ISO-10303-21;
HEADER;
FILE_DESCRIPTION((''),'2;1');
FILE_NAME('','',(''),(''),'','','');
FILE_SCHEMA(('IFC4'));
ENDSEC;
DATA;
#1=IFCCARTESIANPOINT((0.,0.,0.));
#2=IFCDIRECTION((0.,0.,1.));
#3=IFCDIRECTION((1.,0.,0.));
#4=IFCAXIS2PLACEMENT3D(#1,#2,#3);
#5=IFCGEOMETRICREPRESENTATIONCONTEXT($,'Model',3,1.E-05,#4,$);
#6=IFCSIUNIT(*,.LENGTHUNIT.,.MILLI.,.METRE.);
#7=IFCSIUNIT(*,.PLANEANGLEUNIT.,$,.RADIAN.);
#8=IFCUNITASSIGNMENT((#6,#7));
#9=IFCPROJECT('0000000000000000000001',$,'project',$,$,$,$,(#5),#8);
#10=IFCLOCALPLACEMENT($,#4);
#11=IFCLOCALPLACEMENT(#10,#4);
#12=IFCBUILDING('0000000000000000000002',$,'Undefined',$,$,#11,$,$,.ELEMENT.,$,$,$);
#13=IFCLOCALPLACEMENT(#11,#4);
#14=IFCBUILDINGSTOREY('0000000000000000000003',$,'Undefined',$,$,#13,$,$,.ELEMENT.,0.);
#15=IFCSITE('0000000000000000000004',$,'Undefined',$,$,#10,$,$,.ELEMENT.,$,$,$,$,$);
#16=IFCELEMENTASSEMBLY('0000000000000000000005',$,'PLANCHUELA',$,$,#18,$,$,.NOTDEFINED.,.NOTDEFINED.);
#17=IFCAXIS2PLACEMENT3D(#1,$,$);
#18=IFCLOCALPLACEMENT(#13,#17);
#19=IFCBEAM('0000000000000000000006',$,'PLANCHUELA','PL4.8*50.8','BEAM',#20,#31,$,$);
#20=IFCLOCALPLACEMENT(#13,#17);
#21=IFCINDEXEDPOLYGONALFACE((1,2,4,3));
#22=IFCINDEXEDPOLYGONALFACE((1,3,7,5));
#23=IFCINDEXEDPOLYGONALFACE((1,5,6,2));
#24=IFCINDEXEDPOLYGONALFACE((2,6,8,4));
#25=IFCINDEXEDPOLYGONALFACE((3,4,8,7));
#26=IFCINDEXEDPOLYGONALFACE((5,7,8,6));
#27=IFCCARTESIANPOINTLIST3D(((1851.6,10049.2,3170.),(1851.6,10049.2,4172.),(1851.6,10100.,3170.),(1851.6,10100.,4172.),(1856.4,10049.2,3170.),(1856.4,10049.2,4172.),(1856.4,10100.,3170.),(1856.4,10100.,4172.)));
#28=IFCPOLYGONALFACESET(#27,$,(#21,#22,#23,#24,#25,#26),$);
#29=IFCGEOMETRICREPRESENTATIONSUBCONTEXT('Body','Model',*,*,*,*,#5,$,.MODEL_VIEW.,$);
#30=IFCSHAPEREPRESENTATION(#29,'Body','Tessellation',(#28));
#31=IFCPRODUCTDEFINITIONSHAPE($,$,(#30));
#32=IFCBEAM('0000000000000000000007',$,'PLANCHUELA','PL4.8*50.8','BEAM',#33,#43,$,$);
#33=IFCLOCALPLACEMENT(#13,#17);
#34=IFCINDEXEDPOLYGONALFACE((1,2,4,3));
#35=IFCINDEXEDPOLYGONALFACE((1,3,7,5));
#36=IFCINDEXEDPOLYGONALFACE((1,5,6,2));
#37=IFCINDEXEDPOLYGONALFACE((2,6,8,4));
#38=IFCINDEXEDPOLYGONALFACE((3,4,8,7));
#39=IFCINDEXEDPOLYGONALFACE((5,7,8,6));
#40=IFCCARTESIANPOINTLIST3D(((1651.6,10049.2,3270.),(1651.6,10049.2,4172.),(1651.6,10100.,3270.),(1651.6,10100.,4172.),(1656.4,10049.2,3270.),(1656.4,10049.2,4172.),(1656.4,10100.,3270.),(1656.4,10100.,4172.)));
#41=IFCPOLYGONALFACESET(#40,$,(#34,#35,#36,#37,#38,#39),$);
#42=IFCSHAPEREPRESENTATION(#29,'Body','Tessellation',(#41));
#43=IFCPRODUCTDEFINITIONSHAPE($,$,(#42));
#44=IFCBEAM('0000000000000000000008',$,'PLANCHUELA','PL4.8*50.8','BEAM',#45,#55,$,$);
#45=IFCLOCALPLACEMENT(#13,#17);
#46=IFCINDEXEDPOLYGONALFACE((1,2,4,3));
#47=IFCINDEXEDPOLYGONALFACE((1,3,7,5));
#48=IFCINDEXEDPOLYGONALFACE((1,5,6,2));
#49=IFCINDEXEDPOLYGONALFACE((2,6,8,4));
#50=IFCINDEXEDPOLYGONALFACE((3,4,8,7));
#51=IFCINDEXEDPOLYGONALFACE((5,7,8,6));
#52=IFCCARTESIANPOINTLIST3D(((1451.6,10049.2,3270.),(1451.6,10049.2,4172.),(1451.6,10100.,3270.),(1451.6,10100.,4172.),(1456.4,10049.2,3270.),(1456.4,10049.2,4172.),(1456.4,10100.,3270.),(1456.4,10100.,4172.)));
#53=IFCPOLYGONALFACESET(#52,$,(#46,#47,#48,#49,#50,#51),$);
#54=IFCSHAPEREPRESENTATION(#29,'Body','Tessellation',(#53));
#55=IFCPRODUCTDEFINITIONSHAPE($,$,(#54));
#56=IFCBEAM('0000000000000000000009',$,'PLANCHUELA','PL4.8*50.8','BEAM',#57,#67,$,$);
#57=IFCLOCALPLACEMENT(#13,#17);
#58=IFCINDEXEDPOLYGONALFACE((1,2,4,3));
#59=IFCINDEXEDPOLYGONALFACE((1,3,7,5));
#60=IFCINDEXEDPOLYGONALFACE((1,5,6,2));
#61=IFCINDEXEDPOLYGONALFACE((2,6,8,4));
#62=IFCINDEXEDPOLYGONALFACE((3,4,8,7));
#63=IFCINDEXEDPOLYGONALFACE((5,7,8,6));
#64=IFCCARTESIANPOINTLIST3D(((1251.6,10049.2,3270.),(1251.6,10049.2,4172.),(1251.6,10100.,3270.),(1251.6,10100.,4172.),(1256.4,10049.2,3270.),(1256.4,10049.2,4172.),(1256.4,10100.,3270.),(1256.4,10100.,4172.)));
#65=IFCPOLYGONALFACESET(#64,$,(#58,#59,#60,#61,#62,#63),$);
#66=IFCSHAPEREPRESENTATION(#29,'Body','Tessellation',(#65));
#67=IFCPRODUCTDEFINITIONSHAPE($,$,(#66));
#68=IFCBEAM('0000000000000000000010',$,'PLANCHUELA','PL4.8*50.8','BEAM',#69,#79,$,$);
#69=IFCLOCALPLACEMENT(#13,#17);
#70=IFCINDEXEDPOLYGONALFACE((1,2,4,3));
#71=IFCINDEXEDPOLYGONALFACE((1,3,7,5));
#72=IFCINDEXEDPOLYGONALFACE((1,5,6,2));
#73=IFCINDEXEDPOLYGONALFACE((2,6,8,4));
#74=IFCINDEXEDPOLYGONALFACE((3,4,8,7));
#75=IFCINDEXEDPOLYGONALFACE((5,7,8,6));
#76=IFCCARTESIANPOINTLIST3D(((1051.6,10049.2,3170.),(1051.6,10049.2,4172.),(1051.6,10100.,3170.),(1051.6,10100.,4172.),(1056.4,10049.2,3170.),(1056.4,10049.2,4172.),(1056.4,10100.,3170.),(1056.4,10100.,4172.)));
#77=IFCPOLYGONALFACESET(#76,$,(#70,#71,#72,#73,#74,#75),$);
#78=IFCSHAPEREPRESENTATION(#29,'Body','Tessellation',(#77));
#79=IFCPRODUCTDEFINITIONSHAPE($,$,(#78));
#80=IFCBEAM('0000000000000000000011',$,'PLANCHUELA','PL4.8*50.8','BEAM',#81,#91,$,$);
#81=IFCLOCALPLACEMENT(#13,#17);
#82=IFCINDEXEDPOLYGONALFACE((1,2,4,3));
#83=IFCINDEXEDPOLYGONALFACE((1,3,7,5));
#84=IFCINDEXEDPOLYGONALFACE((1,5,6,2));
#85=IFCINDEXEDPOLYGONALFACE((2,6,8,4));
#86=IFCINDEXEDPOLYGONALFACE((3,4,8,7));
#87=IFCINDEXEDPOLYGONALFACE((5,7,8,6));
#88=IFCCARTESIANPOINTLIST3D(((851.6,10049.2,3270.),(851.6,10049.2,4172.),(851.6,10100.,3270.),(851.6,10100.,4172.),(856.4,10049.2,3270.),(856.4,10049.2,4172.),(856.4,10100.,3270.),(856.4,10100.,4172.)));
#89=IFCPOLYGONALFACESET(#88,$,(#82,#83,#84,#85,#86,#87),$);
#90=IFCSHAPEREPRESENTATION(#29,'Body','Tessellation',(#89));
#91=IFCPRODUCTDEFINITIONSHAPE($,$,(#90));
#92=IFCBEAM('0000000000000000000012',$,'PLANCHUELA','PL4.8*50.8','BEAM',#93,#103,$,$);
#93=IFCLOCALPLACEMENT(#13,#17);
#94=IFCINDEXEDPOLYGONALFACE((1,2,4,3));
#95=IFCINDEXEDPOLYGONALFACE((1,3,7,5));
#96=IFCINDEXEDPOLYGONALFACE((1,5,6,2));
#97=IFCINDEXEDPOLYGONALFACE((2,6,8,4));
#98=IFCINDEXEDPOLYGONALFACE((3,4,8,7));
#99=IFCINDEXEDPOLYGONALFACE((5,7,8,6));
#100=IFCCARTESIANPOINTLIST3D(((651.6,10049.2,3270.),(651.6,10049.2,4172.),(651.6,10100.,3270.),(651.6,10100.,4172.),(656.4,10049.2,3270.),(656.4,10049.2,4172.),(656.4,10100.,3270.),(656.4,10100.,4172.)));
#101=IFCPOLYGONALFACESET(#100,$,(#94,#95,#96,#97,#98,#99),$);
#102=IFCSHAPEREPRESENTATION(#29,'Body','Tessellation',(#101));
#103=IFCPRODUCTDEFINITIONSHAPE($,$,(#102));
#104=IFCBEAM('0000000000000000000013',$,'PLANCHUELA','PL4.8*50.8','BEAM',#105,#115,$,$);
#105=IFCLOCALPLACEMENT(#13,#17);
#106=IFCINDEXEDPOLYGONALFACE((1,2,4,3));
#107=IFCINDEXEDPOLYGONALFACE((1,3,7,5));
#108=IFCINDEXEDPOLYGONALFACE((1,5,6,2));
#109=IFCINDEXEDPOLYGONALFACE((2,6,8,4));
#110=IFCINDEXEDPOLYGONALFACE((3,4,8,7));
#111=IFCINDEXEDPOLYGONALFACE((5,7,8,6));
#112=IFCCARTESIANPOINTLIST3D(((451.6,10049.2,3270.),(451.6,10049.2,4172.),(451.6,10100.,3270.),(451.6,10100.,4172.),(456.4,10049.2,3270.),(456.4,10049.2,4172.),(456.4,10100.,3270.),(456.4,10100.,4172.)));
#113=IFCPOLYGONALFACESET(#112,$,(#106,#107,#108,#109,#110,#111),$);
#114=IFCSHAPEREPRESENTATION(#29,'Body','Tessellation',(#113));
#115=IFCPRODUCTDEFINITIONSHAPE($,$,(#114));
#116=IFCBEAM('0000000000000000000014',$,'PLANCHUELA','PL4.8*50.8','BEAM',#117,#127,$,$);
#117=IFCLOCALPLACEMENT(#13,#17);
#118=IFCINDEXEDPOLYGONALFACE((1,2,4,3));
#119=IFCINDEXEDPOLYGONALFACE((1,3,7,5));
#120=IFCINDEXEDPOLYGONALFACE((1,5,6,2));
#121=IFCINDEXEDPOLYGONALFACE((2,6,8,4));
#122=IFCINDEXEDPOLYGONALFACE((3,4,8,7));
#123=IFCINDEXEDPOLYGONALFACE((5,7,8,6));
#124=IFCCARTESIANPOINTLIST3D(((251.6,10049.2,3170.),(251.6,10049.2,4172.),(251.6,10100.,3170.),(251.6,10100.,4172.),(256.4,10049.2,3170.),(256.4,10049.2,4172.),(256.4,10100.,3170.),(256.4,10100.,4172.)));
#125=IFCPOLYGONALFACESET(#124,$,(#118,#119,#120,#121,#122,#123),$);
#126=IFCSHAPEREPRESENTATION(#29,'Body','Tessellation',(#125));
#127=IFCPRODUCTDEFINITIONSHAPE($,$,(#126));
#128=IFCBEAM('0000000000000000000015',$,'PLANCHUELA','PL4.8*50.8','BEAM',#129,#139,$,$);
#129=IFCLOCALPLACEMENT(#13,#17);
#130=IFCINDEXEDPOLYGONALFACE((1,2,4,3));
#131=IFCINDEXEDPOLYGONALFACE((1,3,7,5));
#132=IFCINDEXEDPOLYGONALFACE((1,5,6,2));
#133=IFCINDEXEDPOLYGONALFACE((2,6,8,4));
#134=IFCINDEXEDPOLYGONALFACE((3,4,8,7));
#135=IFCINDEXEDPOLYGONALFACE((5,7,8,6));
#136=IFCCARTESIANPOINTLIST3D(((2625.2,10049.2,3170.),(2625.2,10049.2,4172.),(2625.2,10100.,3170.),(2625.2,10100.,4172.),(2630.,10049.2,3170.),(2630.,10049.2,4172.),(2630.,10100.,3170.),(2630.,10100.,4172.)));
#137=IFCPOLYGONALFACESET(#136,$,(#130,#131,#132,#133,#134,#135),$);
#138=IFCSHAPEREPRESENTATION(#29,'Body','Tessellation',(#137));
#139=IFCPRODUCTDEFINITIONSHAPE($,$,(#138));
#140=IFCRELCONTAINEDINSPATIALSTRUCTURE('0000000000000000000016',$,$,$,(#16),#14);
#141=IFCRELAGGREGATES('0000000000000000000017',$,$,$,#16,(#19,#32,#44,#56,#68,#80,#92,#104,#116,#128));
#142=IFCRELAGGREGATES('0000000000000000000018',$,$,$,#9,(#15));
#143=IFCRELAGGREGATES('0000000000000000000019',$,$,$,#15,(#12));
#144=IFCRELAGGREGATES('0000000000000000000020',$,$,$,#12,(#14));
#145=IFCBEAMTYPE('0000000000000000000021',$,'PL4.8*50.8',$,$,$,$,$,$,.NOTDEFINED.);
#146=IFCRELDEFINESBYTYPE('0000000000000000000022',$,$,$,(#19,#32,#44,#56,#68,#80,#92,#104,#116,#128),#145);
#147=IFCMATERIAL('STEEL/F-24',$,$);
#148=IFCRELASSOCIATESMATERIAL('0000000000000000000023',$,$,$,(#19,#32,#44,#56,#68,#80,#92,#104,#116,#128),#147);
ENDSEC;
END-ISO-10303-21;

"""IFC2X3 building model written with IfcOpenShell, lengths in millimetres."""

from ifc_helpers import new_model, si_unit, frame, origin_with_axes, origin_2d_with_axis, place, context, subcontext, project, spatial, rectangle, extrude, material, type_object, element, aggregate, save


model = new_model("IFC2X3")

# Units and contexts
model_context = context("Model", 3, precision=1e-05, world=origin_with_axes())
body_context = subcontext(model_context, "Body", "Model", "MODEL_VIEW")
ifc_project = project(units=[si_unit("LENGTHUNIT", "METRE", prefix="MILLI"), si_unit("PLANEANGLEUNIT", "RADIAN")], contexts=[model_context])

# Site, building, storey
site_placement = place(None, origin_with_axes())
site = spatial("IfcSite", under=ifc_project, at=site_placement, Name="Undefined", CompositionType="ELEMENT")
building_placement = place(site_placement, origin_with_axes())
building = spatial("IfcBuilding", under=site, at=building_placement, Name="Undefined", CompositionType="ELEMENT")
storey_placement = place(building_placement, origin_with_axes())
storey = spatial("IfcBuildingStorey", under=building, at=storey_placement, Name="Undefined", CompositionType="ELEMENT", Elevation=0.0)

# Element assembly, beams
assembly_1_placement = place(storey_placement, origin_with_axes())
assembly_1 = element("IfcElementAssembly", 1, at=assembly_1_placement, inside=storey, Name="PLANCHUELA", AssemblyPlace="NOTDEFINED", PredefinedType="NOTDEFINED")
ifc_material_1 = material(Name="STEEL/F-24")
beam_type = type_object("IfcBeamType", Name="PL4.8*50.8", PredefinedType="NOTDEFINED")
beam_1_placement = place(assembly_1_placement, frame((1854.0, 10074.6, 4172.0), z_axis=(0.0, -1.0, 0.0), x_axis=(0.0, 0.0, -1.0)))
beam_1 = element("IfcBeam", 2, at=beam_1_placement, type_object=beam_type, material=ifc_material_1, Name="PLANCHUELA", Description="PL4.8*50.8", ObjectType="BEAM", context=body_context, shape_type="SweptSolid", body=[
    extrude(rectangle(XDim=4.8, YDim=50.8, at=origin_2d_with_axis()), frame((1002.0, 0.0, 0.0), z_axis=(-1.0, 0.0, 0.0), x_axis=(0.0, -1.0, 0.0)), (0.0, 0.0, 1.0), 1002.0),
])
beam_2_placement = place(assembly_1_placement, frame((1654.0, 10074.6, 4172.0), z_axis=(0.0, -1.0, 0.0), x_axis=(0.0, 0.0, -1.0)))
beam_2 = element("IfcBeam", 3, at=beam_2_placement, type_object=beam_type, material=ifc_material_1, Name="PLANCHUELA", Description="PL4.8*50.8", ObjectType="BEAM", context=body_context, shape_type="SweptSolid", body=[
    extrude(rectangle(XDim=4.8, YDim=50.8, at=origin_2d_with_axis()), frame((902.0, 0.0, 0.0), z_axis=(-1.0, 0.0, 0.0), x_axis=(0.0, -1.0, 0.0)), (0.0, 0.0, 1.0), 902.0),
])
beam_3_placement = place(assembly_1_placement, frame((1454.0, 10074.6, 4172.0), z_axis=(0.0, -1.0, 0.0), x_axis=(0.0, 0.0, -1.0)))
beam_3 = element("IfcBeam", 4, at=beam_3_placement, type_object=beam_type, material=ifc_material_1, Name="PLANCHUELA", Description="PL4.8*50.8", ObjectType="BEAM", context=body_context, shape_type="SweptSolid", body=[
    extrude(rectangle(XDim=4.8, YDim=50.8, at=origin_2d_with_axis()), frame((902.0, 0.0, 0.0), z_axis=(-1.0, 0.0, 0.0), x_axis=(0.0, -1.0, 0.0)), (0.0, 0.0, 1.0), 902.0),
])
beam_4_placement = place(assembly_1_placement, frame((1254.0, 10074.6, 4172.0), z_axis=(0.0, -1.0, 0.0), x_axis=(0.0, 0.0, -1.0)))
beam_4 = element("IfcBeam", 5, at=beam_4_placement, type_object=beam_type, material=ifc_material_1, Name="PLANCHUELA", Description="PL4.8*50.8", ObjectType="BEAM", context=body_context, shape_type="SweptSolid", body=[
    extrude(rectangle(XDim=4.8, YDim=50.8, at=origin_2d_with_axis()), frame((902.0, 0.0, 0.0), z_axis=(-1.0, 0.0, 0.0), x_axis=(0.0, -1.0, 0.0)), (0.0, 0.0, 1.0), 902.0),
])
beam_5_placement = place(assembly_1_placement, frame((1054.0, 10074.6, 4172.0), z_axis=(0.0, -1.0, 0.0), x_axis=(0.0, 0.0, -1.0)))
beam_5 = element("IfcBeam", 6, at=beam_5_placement, type_object=beam_type, material=ifc_material_1, Name="PLANCHUELA", Description="PL4.8*50.8", ObjectType="BEAM", context=body_context, shape_type="SweptSolid", body=[
    extrude(rectangle(XDim=4.8, YDim=50.8, at=origin_2d_with_axis()), frame((1002.0, 0.0, 0.0), z_axis=(-1.0, 0.0, 0.0), x_axis=(0.0, -1.0, 0.0)), (0.0, 0.0, 1.0), 1002.0),
])
beam_6_placement = place(assembly_1_placement, frame((854.0, 10074.6, 4172.0), z_axis=(0.0, -1.0, 0.0), x_axis=(0.0, 0.0, -1.0)))
beam_6 = element("IfcBeam", 7, at=beam_6_placement, type_object=beam_type, material=ifc_material_1, Name="PLANCHUELA", Description="PL4.8*50.8", ObjectType="BEAM", context=body_context, shape_type="SweptSolid", body=[
    extrude(rectangle(XDim=4.8, YDim=50.8, at=origin_2d_with_axis()), frame((902.0, 0.0, 0.0), z_axis=(-1.0, 0.0, 0.0), x_axis=(0.0, -1.0, 0.0)), (0.0, 0.0, 1.0), 902.0),
])
beam_7_placement = place(assembly_1_placement, frame((654.0, 10074.6, 4172.0), z_axis=(0.0, -1.0, 0.0), x_axis=(0.0, 0.0, -1.0)))
beam_7 = element("IfcBeam", 8, at=beam_7_placement, type_object=beam_type, material=ifc_material_1, Name="PLANCHUELA", Description="PL4.8*50.8", ObjectType="BEAM", context=body_context, shape_type="SweptSolid", body=[
    extrude(rectangle(XDim=4.8, YDim=50.8, at=origin_2d_with_axis()), frame((902.0, 0.0, 0.0), z_axis=(-1.0, 0.0, 0.0), x_axis=(0.0, -1.0, 0.0)), (0.0, 0.0, 1.0), 902.0),
])
beam_8_placement = place(assembly_1_placement, frame((454.0, 10074.6, 4172.0), z_axis=(0.0, -1.0, 0.0), x_axis=(0.0, 0.0, -1.0)))
beam_8 = element("IfcBeam", 9, at=beam_8_placement, type_object=beam_type, material=ifc_material_1, Name="PLANCHUELA", Description="PL4.8*50.8", ObjectType="BEAM", context=body_context, shape_type="SweptSolid", body=[
    extrude(rectangle(XDim=4.8, YDim=50.8, at=origin_2d_with_axis()), frame((902.0, 0.0, 0.0), z_axis=(-1.0, 0.0, 0.0), x_axis=(0.0, -1.0, 0.0)), (0.0, 0.0, 1.0), 902.0),
])
beam_9_placement = place(assembly_1_placement, frame((254.0, 10074.6, 4172.0), z_axis=(0.0, -1.0, 0.0), x_axis=(0.0, 0.0, -1.0)))
beam_9 = element("IfcBeam", 10, at=beam_9_placement, type_object=beam_type, material=ifc_material_1, Name="PLANCHUELA", Description="PL4.8*50.8", ObjectType="BEAM", context=body_context, shape_type="SweptSolid", body=[
    extrude(rectangle(XDim=4.8, YDim=50.8, at=origin_2d_with_axis()), frame((1002.0, 0.0, 0.0), z_axis=(-1.0, 0.0, 0.0), x_axis=(0.0, -1.0, 0.0)), (0.0, 0.0, 1.0), 1002.0),
])
beam_10_placement = place(assembly_1_placement, frame((2627.6, 10074.6, 4172.0), z_axis=(0.0, -1.0, 0.0), x_axis=(0.0, 0.0, -1.0)))
beam_10 = element("IfcBeam", 11, at=beam_10_placement, type_object=beam_type, material=ifc_material_1, Name="PLANCHUELA", Description="PL4.8*50.8", ObjectType="BEAM", context=body_context, shape_type="SweptSolid", body=[
    extrude(rectangle(XDim=4.8, YDim=50.8, at=origin_2d_with_axis()), frame((1002.0, 0.0, 0.0), z_axis=(-1.0, 0.0, 0.0), x_axis=(0.0, -1.0, 0.0)), (0.0, 0.0, 1.0), 1002.0),
])
aggregate(assembly_1, [beam_1, beam_2, beam_3, beam_4, beam_5, beam_6, beam_7, beam_8, beam_9, beam_10])

save(model, "model.ifc")
